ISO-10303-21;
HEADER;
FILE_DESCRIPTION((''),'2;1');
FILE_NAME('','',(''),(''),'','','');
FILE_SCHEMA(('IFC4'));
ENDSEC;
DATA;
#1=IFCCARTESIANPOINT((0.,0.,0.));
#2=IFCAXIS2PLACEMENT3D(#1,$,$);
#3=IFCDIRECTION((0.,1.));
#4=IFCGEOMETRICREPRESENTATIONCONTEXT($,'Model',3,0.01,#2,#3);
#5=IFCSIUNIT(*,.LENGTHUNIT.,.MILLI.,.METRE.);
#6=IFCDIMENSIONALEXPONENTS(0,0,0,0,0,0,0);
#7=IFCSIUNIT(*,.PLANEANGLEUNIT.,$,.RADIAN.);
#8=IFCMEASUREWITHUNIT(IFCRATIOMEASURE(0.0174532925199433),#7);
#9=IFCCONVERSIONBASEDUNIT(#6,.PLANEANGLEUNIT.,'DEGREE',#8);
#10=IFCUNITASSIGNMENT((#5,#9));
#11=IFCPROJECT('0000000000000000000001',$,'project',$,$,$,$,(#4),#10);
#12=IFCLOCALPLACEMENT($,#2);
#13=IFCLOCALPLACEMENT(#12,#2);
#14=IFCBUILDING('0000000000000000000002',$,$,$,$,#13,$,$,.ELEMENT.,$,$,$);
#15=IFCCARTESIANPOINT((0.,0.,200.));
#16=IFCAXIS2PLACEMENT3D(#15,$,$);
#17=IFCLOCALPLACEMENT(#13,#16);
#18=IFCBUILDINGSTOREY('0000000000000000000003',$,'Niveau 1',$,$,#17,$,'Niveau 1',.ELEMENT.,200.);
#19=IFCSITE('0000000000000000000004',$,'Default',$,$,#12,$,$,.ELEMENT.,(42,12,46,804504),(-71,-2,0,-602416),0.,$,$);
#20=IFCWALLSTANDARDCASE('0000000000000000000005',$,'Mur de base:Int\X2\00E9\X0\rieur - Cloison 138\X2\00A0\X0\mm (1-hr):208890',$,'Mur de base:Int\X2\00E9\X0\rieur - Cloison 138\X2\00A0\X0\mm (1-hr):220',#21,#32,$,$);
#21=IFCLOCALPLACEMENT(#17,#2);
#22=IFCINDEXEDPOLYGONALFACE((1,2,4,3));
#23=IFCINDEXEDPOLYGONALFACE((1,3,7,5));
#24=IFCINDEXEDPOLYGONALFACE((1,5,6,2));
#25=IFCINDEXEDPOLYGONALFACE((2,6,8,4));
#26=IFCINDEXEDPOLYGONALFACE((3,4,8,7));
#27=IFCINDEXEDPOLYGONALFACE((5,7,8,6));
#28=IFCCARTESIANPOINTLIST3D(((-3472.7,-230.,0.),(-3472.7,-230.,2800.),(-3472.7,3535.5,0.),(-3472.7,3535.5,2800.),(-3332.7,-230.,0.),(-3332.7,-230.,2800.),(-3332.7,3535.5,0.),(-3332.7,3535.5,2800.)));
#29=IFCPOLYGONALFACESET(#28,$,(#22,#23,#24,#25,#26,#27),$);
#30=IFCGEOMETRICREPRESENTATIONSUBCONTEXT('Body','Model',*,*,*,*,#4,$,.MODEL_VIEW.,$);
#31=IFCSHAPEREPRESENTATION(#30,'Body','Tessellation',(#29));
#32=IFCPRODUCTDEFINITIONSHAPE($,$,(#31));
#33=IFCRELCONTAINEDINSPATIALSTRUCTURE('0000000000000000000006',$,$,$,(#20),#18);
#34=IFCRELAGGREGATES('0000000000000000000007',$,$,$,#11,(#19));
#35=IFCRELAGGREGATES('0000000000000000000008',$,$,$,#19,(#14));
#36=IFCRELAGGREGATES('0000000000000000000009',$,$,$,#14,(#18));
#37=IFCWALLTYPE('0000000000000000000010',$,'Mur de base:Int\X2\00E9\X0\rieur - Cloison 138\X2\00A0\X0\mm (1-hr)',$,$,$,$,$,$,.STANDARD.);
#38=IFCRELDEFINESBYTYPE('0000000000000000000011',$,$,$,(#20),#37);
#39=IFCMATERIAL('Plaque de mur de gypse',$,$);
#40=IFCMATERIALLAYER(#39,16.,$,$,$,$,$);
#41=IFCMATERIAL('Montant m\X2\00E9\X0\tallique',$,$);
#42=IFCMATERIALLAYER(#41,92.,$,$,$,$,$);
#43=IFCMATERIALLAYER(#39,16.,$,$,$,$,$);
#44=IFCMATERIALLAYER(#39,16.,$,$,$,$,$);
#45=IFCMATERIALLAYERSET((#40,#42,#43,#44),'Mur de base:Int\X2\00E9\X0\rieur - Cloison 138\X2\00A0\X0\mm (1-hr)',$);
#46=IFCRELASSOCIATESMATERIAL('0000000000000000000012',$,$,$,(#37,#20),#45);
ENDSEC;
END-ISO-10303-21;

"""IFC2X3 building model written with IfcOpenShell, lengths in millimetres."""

from ifc_helpers import new_model, entity, si_unit, converted_unit, direction, frame, frame_2d, origin, place, context, subcontext, project, spatial, polyline, rectangle, extrude, clip, bounded_halfspace, material, layer, layer_set, layer_usage, type_object, element, save


model = new_model("IFC2X3")

# Units and contexts
model_context = context("Model", 3, precision=0.01, world=origin(), true_north=direction((0.0, 1.0)))
body_context = subcontext(model_context, "Body", "Model", "MODEL_VIEW")
ifc_project = project(units=[si_unit("LENGTHUNIT", "METRE", prefix="MILLI"), converted_unit("PLANEANGLEUNIT", "DEGREE", entity("IfcRatioMeasure", 0.0174532925199433), si_unit("PLANEANGLEUNIT", "RADIAN"), dimensions=[0, 0, 0, 0, 0, 0, 0])], contexts=[model_context])

# Site, building, storey
site_placement = place(None, origin())
site = spatial("IfcSite", under=ifc_project, at=site_placement, Name="Default", CompositionType="ELEMENT", RefLatitude=(42, 12, 46, 804504), RefLongitude=(-71, -2, 0, -602416), RefElevation=0.0)
building_placement = place(site_placement, origin())
building = spatial("IfcBuilding", under=site, at=building_placement, CompositionType="ELEMENT")
storey_placement = place(building_placement, frame((0.0, 0.0, 200.0)))
storey = spatial("IfcBuildingStorey", under=building, at=storey_placement, Name="Niveau 1", LongName="Niveau 1", CompositionType="ELEMENT", Elevation=200.0)

# Wall
ifc_material_1 = material(Name="Plaque de mur de gypse")
ifc_material_2 = material(Name="Montant métallique")
ifc_layer_1 = layer(ifc_material_1, 16.0)
ifc_layer_2 = layer(ifc_material_2, 92.0)
ifc_layer_3 = layer(ifc_material_1, 16.0)
ifc_layer_4 = layer(ifc_material_1, 16.0)
ifc_layer_set_1 = layer_set([ifc_layer_1, ifc_layer_2, ifc_layer_3, ifc_layer_4], Name="Mur de base:Intérieur - Cloison 138 mm (1-hr)")
wall_type_1 = type_object("IfcWallType", Name="Mur de base:Intérieur - Cloison 138 mm (1-hr)", PredefinedType="STANDARD", material=ifc_layer_set_1)
ifc_layer_usage_1 = layer_usage(ifc_layer_set_1, "AXIS2", "NEGATIVE", 70.0)
wall_1_placement = place(storey_placement, frame((-3402.7, 3535.5, 0.0), z_axis=(0.0, 0.0, 1.0), x_axis=(0.0, -1.0, 0.0)))
element("IfcWallStandardCase", 1, at=wall_1_placement, inside=storey, type_object=wall_type_1, material=ifc_layer_usage_1, Name="Mur de base:Intérieur - Cloison 138 mm (1-hr):208890", ObjectType="Mur de base:Intérieur - Cloison 138 mm (1-hr):220", context=body_context, shape_type="Clipping", body=[
    clip(extrude(rectangle(XDim=3765.5, YDim=140.0, at=frame_2d((1882.8, 0.0), x_axis=(-1.0, 0.0))), origin(), (0.0, 0.0, 1.0), 2800.0), bounded_halfspace(frame((0.0, -70.0, 2800.0), z_axis=(0.0, 0.0, -1.0), x_axis=(-1.0, 0.0, 0.0)), True, frame((0.0, -70.0, 2800.0)), polyline([(0.0, 0.0), (3765.5, 0.0), (3765.5, 110.0), (3765.5, 140.0), (0.0, 140.0), (0.0, 0.0)]))),
])

save(model, "model.ifc")
